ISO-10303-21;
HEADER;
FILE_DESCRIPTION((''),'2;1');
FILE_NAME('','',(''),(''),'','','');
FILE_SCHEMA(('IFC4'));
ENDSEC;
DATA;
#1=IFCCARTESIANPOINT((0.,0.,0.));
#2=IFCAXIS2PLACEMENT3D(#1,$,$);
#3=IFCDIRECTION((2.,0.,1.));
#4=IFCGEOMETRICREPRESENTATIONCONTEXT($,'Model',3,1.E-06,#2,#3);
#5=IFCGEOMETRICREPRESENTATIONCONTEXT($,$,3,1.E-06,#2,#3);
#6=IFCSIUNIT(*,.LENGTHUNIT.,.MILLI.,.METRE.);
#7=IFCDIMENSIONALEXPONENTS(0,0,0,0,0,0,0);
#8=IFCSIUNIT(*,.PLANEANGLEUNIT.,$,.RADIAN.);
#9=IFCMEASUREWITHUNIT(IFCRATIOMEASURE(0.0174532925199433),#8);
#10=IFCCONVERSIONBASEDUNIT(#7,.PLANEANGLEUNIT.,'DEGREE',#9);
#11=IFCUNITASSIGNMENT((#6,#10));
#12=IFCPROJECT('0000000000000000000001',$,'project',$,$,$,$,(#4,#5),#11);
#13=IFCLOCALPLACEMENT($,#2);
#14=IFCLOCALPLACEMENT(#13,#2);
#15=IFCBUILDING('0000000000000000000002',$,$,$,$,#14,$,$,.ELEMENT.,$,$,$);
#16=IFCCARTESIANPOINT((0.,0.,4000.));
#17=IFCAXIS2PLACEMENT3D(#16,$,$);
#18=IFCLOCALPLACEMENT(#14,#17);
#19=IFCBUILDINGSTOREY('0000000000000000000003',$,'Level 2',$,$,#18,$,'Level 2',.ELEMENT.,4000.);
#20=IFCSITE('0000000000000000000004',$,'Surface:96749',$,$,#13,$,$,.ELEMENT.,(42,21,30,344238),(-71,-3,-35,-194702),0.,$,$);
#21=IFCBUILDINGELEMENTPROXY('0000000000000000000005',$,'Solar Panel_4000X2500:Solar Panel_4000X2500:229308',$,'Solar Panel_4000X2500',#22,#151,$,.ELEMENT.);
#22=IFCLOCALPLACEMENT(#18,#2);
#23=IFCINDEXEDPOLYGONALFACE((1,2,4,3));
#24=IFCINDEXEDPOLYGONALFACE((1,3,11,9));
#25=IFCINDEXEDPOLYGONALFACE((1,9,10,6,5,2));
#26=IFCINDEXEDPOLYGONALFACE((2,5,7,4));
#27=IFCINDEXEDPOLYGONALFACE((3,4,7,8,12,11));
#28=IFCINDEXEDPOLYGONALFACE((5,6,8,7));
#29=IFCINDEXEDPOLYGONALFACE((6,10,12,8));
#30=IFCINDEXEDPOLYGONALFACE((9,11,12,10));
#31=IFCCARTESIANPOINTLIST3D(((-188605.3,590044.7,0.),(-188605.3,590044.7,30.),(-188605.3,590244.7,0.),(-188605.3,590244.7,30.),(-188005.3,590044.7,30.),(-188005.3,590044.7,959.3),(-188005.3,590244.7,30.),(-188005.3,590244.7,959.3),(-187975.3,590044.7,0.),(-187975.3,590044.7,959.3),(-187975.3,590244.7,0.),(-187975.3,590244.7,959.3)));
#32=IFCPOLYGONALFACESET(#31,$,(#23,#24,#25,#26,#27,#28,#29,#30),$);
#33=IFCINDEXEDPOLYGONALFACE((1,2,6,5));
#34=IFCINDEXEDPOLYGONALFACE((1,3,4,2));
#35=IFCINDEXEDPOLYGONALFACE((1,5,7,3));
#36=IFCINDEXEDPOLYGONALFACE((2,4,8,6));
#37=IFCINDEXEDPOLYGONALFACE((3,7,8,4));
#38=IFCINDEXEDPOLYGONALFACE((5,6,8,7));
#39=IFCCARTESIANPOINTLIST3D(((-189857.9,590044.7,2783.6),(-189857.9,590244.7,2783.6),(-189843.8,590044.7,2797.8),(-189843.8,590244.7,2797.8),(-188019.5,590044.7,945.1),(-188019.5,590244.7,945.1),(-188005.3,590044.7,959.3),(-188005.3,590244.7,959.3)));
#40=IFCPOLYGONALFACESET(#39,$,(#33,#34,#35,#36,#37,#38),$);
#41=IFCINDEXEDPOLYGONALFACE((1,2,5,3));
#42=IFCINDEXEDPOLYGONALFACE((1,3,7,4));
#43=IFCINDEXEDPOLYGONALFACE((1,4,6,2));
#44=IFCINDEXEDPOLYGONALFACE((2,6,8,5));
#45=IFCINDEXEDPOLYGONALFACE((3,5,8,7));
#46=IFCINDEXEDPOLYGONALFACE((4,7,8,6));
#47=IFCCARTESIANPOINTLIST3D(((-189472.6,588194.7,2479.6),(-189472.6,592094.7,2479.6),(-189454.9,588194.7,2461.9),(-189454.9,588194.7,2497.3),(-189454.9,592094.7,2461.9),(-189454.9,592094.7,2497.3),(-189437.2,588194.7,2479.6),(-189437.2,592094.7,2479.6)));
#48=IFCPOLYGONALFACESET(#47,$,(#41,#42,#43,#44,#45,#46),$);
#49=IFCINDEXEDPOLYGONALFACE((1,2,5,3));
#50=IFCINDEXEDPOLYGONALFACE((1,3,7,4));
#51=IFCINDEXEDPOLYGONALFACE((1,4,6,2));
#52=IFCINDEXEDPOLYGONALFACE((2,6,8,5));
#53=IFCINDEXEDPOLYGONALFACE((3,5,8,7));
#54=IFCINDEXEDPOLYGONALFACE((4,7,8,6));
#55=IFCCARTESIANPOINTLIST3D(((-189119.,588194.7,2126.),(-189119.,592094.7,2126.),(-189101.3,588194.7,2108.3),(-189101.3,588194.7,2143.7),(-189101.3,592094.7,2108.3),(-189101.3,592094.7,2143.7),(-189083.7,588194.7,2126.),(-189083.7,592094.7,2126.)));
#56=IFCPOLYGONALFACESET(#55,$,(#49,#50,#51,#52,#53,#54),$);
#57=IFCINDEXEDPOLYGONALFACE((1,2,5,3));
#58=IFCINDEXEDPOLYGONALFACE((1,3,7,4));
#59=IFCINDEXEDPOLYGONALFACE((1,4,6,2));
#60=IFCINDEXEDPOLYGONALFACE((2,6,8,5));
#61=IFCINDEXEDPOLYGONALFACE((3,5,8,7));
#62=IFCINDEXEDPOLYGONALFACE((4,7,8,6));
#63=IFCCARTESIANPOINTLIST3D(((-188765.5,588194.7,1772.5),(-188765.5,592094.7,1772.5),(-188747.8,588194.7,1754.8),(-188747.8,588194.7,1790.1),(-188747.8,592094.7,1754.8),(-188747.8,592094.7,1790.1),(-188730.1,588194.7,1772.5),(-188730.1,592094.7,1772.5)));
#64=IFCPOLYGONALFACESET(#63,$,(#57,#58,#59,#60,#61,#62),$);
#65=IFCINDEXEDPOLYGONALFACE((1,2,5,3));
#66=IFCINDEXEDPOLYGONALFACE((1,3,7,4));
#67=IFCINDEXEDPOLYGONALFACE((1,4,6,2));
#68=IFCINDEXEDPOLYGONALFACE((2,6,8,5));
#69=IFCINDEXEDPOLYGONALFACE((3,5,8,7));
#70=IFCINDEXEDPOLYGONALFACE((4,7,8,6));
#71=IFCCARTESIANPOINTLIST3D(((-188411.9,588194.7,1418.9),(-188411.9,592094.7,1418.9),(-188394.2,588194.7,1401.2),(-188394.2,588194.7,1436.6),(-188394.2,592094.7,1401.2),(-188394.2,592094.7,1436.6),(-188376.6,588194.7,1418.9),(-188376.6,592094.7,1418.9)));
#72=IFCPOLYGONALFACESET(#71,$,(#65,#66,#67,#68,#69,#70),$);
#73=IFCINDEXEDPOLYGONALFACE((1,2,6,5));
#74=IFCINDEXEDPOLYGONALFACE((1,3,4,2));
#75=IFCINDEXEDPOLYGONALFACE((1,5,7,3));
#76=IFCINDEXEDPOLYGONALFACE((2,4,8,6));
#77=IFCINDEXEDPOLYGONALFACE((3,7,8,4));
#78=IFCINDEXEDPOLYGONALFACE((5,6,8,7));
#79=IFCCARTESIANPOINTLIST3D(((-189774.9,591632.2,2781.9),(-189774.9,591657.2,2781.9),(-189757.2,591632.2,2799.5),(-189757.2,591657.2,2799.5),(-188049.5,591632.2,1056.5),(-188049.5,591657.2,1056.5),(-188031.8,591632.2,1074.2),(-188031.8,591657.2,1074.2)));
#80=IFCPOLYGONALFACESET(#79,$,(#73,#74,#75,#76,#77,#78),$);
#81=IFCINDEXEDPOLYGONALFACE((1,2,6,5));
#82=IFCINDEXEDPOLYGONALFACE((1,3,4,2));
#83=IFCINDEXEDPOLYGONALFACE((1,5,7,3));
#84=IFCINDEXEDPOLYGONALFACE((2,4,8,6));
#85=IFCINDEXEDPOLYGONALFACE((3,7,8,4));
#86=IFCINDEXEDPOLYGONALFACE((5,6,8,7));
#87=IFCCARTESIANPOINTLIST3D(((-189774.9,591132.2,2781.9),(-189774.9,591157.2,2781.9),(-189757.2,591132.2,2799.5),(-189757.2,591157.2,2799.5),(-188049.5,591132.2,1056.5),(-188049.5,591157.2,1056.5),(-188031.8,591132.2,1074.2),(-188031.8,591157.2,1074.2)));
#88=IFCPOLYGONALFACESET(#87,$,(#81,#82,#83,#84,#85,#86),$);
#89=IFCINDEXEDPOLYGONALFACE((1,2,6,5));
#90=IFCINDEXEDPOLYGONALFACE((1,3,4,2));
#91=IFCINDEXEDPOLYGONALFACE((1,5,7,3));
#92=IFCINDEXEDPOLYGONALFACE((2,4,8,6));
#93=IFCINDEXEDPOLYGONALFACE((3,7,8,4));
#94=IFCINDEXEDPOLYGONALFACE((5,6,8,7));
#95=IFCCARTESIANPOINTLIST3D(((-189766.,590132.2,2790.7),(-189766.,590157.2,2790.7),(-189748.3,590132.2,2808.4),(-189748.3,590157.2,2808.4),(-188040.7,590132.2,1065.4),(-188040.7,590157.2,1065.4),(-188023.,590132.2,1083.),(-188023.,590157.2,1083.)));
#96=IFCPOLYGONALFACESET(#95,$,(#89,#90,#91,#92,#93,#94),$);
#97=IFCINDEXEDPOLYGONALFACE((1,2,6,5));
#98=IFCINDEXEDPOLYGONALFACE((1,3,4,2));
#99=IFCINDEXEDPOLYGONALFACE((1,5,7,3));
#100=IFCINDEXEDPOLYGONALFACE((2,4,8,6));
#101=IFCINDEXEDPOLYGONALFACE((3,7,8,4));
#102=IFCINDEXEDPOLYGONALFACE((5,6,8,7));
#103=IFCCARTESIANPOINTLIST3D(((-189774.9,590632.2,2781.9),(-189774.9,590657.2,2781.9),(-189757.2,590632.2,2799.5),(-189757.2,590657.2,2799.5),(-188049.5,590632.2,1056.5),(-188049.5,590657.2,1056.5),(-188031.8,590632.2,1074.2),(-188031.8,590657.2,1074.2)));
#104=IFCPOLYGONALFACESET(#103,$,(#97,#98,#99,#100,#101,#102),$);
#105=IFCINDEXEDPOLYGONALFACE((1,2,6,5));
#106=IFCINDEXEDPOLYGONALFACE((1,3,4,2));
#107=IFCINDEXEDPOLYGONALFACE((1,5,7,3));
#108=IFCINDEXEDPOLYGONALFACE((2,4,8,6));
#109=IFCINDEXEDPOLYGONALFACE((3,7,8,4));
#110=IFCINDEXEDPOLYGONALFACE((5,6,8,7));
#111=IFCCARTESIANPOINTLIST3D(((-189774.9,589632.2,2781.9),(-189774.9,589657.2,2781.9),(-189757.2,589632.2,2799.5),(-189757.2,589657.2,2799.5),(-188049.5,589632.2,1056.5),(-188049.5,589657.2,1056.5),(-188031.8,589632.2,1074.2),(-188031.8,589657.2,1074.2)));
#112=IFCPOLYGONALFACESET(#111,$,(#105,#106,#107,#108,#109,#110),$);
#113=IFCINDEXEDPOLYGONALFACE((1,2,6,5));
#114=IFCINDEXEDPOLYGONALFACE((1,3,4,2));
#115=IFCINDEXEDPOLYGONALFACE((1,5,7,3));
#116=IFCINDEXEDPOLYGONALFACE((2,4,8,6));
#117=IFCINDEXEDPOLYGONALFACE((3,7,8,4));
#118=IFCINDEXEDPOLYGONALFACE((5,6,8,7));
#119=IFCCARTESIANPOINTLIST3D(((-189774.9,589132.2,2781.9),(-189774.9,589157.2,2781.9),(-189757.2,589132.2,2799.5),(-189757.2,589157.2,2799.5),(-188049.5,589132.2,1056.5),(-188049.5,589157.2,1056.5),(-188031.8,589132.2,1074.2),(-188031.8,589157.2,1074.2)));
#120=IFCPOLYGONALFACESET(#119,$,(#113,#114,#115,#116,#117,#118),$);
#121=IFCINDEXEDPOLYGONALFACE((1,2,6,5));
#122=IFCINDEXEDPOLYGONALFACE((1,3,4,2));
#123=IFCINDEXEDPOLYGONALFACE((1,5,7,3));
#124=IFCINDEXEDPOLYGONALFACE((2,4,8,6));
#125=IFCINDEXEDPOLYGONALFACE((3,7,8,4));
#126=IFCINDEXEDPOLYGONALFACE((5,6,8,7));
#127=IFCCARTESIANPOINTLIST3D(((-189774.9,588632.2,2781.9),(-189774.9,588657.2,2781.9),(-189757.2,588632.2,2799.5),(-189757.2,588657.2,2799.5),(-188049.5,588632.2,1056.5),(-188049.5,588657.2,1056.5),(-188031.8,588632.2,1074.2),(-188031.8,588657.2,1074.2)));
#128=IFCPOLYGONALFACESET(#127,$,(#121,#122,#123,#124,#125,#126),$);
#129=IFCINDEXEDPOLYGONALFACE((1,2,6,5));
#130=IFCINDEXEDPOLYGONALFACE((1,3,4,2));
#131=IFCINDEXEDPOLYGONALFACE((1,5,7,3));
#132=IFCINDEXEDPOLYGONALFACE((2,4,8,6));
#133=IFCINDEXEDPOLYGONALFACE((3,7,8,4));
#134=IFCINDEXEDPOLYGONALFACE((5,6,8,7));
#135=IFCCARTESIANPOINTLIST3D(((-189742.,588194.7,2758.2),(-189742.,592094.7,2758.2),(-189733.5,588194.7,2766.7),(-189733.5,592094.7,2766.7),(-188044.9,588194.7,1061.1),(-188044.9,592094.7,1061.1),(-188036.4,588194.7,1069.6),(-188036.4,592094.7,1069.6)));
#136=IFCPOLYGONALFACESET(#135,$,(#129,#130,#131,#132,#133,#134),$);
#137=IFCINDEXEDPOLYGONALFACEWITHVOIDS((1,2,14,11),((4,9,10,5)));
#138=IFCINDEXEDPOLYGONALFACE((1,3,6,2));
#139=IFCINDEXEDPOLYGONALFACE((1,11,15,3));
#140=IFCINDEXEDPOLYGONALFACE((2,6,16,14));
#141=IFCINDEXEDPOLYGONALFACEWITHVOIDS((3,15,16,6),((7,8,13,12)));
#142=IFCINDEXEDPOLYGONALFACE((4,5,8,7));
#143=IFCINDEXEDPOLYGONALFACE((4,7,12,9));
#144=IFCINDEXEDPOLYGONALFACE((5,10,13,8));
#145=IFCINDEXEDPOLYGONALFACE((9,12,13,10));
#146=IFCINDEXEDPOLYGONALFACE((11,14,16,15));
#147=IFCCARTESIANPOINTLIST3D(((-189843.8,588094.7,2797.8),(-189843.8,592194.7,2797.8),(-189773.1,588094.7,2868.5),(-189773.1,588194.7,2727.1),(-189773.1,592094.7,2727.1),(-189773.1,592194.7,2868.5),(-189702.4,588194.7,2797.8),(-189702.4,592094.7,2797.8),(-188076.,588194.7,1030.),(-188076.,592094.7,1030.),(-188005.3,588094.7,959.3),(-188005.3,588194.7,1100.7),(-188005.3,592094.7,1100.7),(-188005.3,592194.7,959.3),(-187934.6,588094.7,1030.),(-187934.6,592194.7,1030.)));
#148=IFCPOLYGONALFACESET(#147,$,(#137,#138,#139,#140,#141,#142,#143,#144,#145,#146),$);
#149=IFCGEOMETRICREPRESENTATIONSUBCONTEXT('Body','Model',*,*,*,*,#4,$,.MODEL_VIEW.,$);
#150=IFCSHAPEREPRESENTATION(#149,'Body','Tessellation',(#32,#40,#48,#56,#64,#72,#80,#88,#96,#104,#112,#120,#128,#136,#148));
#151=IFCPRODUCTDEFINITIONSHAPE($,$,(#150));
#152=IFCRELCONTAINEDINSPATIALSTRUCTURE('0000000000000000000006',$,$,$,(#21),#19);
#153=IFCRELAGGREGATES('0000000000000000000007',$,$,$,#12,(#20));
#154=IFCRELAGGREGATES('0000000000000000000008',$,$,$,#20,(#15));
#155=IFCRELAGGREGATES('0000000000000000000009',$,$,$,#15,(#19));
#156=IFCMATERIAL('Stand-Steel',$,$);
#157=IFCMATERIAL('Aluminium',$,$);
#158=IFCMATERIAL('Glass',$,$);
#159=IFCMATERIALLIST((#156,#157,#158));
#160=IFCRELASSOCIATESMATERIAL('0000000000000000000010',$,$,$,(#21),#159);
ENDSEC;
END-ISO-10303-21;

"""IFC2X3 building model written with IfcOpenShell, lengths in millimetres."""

from ifc_helpers import new_model, entity, si_unit, converted_unit, direction, frame, frame_2d, origin, origin_2d_with_axis, place, context, subcontext, project, spatial, polyline, rectangle, outline, extrude, source, transform, mapped, material, material_list, element, save


model = new_model("IFC2X3")

# Units and contexts
model_context = context("Model", 3, precision=1e-06, world=origin(), true_north=direction((2.0, 0.0, 1.0)))
context_of_model = context(None, 3, precision=1e-06, world=origin(), true_north=direction((2.0, 0.0, 1.0)))
body_context = subcontext(model_context, "Body", "Model", "MODEL_VIEW")
ifc_project = project(units=[si_unit("LENGTHUNIT", "METRE", prefix="MILLI"), converted_unit("PLANEANGLEUNIT", "DEGREE", entity("IfcRatioMeasure", 0.0174532925199433), si_unit("PLANEANGLEUNIT", "RADIAN"), dimensions=[0, 0, 0, 0, 0, 0, 0])], contexts=[model_context, context_of_model])

# Site, building, storey
site_placement = place(None, origin())
site = spatial("IfcSite", under=ifc_project, at=site_placement, Name="Surface:96749", CompositionType="ELEMENT", RefLatitude=(42, 21, 30, 344238), RefLongitude=(-71, -3, -35, -194702), RefElevation=0.0)
building_placement = place(site_placement, origin())
building = spatial("IfcBuilding", under=site, at=building_placement, CompositionType="ELEMENT")
storey_placement = place(building_placement, frame((0.0, 0.0, 4000.0)))
storey = spatial("IfcBuildingStorey", under=building, at=storey_placement, Name="Level 2", LongName="Level 2", CompositionType="ELEMENT", Elevation=4000.0)

# Building element proxy
ifc_material_1 = material(Name="Stand-Steel")
ifc_material_2 = material(Name="Aluminium")
ifc_material_3 = material(Name="Glass")
shared_shape = source(origin(), body_context, "Body", "SweptSolid", [
    extrude(outline(polyline([(-629.5, -220.0), (329.8, -220.0), (329.8, 410.0), (299.8, 410.0), (299.8, -190.0), (-629.5, -190.0), (-629.5, -220.0)])), frame((-190.0, -100.0, 299.8), z_axis=(0.0, 1.0, 0.0), x_axis=(0.0, 0.0, -1.0)), (0.0, 0.0, 1.0), 200.0),
    extrude(rectangle(XDim=20.0, YDim=200.0, at=frame_2d((0.0, 0.0), x_axis=(0.0, 1.0))), frame((-7.1, 0.0, 922.2), z_axis=(-0.707107, 0.0, 0.707107), x_axis=(0.0, 1.0, 0.0)), (0.0, 0.0, 1.0), 2600.0),
    extrude(rectangle(XDim=25.0, YDim=25.0, at=frame_2d((0.0, 0.0), x_axis=(1.0, 0.0))), frame((-1449.6, -1950.0, 2449.6), z_axis=(0.0, 1.0, 0.0), x_axis=(-0.707107, 0.0, -0.707107)), (0.0, 0.0, 1.0), 3900.0),
    extrude(rectangle(XDim=25.0, YDim=25.0, at=origin_2d_with_axis()), frame((-1096.0, -1950.0, 2096.0), z_axis=(0.0, 1.0, 0.0), x_axis=(-0.707107, 0.0, -0.707107)), (0.0, 0.0, 1.0), 3900.0),
    extrude(rectangle(XDim=25.0, YDim=25.0, at=origin_2d_with_axis()), frame((-742.5, -1950.0, 1742.5), z_axis=(0.0, 1.0, 0.0), x_axis=(-0.707107, 0.0, -0.707107)), (0.0, 0.0, 1.0), 3900.0),
    extrude(rectangle(XDim=25.0, YDim=25.0, at=frame_2d((0.0, 0.0), x_axis=(1.0, 0.0))), frame((-388.9, -1950.0, 1388.9), z_axis=(0.0, 1.0, 0.0), x_axis=(-0.707107, 0.0, -0.707107)), (0.0, 0.0, 1.0), 3900.0),
    extrude(rectangle(XDim=25.0, YDim=25.0, at=frame_2d((0.0, 0.0), x_axis=(0.0, 1.0))), frame((-35.4, 1500.0, 1035.4), z_axis=(-0.707107, 0.0, 0.707107), x_axis=(0.0, 1.0, 0.0)), (0.0, 0.0, 1.0), 2440.0),
    extrude(rectangle(XDim=25.0, YDim=25.0, at=frame_2d((0.0, 0.0), x_axis=(0.0, 1.0))), frame((-35.4, 1000.0, 1035.4), z_axis=(-0.707107, 0.0, 0.707107), x_axis=(0.0, 1.0, 0.0)), (0.0, 0.0, 1.0), 2440.0),
    extrude(rectangle(XDim=25.0, YDim=25.0, at=frame_2d((0.0, 0.0), x_axis=(0.0, 1.0))), frame((-26.5, 0.0, 1044.2), z_axis=(-0.707107, 0.0, 0.707107), x_axis=(0.0, -1.0, 0.0)), (0.0, 0.0, 1.0), 2440.0),
    extrude(rectangle(XDim=25.0, YDim=25.0, at=frame_2d((0.0, 0.0), x_axis=(0.0, 1.0))), frame((-35.4, 500.0, 1035.4), z_axis=(-0.707107, 0.0, 0.707107), x_axis=(0.0, 1.0, 0.0)), (0.0, 0.0, 1.0), 2440.0),
    extrude(rectangle(XDim=25.0, YDim=25.0, at=frame_2d((0.0, 0.0), x_axis=(0.0, 1.0))), frame((-35.4, -500.0, 1035.4), z_axis=(-0.707107, 0.0, 0.707107), x_axis=(0.0, 1.0, 0.0)), (0.0, 0.0, 1.0), 2440.0),
    extrude(rectangle(XDim=25.0, YDim=25.0, at=frame_2d((0.0, 0.0), x_axis=(0.0, 1.0))), frame((-35.4, -1000.0, 1035.4), z_axis=(-0.707107, 0.0, 0.707107), x_axis=(0.0, 1.0, 0.0)), (0.0, 0.0, 1.0), 2440.0),
    extrude(rectangle(XDim=25.0, YDim=25.0, at=frame_2d((0.0, 0.0), x_axis=(0.0, 1.0))), frame((-35.4, -1500.0, 1035.4), z_axis=(-0.707107, 0.0, 0.707107), x_axis=(0.0, 1.0, 0.0)), (0.0, 0.0, 1.0), 2440.0),
    extrude(rectangle(XDim=2400.0, YDim=12.0, at=frame_2d((0.0, 0.0), x_axis=(1.0, 0.0))), frame((-883.9, -1950.0, 1883.9), z_axis=(0.0, 1.0, 0.0), x_axis=(0.707107, 0.0, -0.707107)), (0.0, 0.0, 1.0), 3900.0),
    extrude(outline(polyline([(-2050.0, -1300.0), (2050.0, -1300.0), (2050.0, 1300.0), (-2050.0, 1300.0), (-2050.0, -1300.0)]), holes=[polyline([(1950.0, -1200.0), (-1950.0, -1200.0), (-1950.0, 1200.0), (1950.0, 1200.0), (1950.0, -1200.0)])]), frame((-919.2, 0.0, 1848.5), z_axis=(0.707107, 0.0, 0.707107), x_axis=(0.0, 1.0, 0.0)), (0.0, 0.0, 1.0), 100.0),
])
ifc_material_list_1 = material_list([ifc_material_1, ifc_material_2, ifc_material_3])
proxy_1_placement = place(storey_placement, frame((-188005.3, 590144.7, 30.0)))
element("IfcBuildingElementProxy", 1, at=proxy_1_placement, inside=storey, material=ifc_material_list_1, Name="Solar Panel_4000X2500:Solar Panel_4000X2500:229308", ObjectType="Solar Panel_4000X2500", CompositionType="ELEMENT", context=body_context, shape_type="MappedRepresentation", body=[
    mapped(shared_shape, transform((0.0, 0.0, 0.0), scale=1.0)),
])

save(model, "model.ifc")
